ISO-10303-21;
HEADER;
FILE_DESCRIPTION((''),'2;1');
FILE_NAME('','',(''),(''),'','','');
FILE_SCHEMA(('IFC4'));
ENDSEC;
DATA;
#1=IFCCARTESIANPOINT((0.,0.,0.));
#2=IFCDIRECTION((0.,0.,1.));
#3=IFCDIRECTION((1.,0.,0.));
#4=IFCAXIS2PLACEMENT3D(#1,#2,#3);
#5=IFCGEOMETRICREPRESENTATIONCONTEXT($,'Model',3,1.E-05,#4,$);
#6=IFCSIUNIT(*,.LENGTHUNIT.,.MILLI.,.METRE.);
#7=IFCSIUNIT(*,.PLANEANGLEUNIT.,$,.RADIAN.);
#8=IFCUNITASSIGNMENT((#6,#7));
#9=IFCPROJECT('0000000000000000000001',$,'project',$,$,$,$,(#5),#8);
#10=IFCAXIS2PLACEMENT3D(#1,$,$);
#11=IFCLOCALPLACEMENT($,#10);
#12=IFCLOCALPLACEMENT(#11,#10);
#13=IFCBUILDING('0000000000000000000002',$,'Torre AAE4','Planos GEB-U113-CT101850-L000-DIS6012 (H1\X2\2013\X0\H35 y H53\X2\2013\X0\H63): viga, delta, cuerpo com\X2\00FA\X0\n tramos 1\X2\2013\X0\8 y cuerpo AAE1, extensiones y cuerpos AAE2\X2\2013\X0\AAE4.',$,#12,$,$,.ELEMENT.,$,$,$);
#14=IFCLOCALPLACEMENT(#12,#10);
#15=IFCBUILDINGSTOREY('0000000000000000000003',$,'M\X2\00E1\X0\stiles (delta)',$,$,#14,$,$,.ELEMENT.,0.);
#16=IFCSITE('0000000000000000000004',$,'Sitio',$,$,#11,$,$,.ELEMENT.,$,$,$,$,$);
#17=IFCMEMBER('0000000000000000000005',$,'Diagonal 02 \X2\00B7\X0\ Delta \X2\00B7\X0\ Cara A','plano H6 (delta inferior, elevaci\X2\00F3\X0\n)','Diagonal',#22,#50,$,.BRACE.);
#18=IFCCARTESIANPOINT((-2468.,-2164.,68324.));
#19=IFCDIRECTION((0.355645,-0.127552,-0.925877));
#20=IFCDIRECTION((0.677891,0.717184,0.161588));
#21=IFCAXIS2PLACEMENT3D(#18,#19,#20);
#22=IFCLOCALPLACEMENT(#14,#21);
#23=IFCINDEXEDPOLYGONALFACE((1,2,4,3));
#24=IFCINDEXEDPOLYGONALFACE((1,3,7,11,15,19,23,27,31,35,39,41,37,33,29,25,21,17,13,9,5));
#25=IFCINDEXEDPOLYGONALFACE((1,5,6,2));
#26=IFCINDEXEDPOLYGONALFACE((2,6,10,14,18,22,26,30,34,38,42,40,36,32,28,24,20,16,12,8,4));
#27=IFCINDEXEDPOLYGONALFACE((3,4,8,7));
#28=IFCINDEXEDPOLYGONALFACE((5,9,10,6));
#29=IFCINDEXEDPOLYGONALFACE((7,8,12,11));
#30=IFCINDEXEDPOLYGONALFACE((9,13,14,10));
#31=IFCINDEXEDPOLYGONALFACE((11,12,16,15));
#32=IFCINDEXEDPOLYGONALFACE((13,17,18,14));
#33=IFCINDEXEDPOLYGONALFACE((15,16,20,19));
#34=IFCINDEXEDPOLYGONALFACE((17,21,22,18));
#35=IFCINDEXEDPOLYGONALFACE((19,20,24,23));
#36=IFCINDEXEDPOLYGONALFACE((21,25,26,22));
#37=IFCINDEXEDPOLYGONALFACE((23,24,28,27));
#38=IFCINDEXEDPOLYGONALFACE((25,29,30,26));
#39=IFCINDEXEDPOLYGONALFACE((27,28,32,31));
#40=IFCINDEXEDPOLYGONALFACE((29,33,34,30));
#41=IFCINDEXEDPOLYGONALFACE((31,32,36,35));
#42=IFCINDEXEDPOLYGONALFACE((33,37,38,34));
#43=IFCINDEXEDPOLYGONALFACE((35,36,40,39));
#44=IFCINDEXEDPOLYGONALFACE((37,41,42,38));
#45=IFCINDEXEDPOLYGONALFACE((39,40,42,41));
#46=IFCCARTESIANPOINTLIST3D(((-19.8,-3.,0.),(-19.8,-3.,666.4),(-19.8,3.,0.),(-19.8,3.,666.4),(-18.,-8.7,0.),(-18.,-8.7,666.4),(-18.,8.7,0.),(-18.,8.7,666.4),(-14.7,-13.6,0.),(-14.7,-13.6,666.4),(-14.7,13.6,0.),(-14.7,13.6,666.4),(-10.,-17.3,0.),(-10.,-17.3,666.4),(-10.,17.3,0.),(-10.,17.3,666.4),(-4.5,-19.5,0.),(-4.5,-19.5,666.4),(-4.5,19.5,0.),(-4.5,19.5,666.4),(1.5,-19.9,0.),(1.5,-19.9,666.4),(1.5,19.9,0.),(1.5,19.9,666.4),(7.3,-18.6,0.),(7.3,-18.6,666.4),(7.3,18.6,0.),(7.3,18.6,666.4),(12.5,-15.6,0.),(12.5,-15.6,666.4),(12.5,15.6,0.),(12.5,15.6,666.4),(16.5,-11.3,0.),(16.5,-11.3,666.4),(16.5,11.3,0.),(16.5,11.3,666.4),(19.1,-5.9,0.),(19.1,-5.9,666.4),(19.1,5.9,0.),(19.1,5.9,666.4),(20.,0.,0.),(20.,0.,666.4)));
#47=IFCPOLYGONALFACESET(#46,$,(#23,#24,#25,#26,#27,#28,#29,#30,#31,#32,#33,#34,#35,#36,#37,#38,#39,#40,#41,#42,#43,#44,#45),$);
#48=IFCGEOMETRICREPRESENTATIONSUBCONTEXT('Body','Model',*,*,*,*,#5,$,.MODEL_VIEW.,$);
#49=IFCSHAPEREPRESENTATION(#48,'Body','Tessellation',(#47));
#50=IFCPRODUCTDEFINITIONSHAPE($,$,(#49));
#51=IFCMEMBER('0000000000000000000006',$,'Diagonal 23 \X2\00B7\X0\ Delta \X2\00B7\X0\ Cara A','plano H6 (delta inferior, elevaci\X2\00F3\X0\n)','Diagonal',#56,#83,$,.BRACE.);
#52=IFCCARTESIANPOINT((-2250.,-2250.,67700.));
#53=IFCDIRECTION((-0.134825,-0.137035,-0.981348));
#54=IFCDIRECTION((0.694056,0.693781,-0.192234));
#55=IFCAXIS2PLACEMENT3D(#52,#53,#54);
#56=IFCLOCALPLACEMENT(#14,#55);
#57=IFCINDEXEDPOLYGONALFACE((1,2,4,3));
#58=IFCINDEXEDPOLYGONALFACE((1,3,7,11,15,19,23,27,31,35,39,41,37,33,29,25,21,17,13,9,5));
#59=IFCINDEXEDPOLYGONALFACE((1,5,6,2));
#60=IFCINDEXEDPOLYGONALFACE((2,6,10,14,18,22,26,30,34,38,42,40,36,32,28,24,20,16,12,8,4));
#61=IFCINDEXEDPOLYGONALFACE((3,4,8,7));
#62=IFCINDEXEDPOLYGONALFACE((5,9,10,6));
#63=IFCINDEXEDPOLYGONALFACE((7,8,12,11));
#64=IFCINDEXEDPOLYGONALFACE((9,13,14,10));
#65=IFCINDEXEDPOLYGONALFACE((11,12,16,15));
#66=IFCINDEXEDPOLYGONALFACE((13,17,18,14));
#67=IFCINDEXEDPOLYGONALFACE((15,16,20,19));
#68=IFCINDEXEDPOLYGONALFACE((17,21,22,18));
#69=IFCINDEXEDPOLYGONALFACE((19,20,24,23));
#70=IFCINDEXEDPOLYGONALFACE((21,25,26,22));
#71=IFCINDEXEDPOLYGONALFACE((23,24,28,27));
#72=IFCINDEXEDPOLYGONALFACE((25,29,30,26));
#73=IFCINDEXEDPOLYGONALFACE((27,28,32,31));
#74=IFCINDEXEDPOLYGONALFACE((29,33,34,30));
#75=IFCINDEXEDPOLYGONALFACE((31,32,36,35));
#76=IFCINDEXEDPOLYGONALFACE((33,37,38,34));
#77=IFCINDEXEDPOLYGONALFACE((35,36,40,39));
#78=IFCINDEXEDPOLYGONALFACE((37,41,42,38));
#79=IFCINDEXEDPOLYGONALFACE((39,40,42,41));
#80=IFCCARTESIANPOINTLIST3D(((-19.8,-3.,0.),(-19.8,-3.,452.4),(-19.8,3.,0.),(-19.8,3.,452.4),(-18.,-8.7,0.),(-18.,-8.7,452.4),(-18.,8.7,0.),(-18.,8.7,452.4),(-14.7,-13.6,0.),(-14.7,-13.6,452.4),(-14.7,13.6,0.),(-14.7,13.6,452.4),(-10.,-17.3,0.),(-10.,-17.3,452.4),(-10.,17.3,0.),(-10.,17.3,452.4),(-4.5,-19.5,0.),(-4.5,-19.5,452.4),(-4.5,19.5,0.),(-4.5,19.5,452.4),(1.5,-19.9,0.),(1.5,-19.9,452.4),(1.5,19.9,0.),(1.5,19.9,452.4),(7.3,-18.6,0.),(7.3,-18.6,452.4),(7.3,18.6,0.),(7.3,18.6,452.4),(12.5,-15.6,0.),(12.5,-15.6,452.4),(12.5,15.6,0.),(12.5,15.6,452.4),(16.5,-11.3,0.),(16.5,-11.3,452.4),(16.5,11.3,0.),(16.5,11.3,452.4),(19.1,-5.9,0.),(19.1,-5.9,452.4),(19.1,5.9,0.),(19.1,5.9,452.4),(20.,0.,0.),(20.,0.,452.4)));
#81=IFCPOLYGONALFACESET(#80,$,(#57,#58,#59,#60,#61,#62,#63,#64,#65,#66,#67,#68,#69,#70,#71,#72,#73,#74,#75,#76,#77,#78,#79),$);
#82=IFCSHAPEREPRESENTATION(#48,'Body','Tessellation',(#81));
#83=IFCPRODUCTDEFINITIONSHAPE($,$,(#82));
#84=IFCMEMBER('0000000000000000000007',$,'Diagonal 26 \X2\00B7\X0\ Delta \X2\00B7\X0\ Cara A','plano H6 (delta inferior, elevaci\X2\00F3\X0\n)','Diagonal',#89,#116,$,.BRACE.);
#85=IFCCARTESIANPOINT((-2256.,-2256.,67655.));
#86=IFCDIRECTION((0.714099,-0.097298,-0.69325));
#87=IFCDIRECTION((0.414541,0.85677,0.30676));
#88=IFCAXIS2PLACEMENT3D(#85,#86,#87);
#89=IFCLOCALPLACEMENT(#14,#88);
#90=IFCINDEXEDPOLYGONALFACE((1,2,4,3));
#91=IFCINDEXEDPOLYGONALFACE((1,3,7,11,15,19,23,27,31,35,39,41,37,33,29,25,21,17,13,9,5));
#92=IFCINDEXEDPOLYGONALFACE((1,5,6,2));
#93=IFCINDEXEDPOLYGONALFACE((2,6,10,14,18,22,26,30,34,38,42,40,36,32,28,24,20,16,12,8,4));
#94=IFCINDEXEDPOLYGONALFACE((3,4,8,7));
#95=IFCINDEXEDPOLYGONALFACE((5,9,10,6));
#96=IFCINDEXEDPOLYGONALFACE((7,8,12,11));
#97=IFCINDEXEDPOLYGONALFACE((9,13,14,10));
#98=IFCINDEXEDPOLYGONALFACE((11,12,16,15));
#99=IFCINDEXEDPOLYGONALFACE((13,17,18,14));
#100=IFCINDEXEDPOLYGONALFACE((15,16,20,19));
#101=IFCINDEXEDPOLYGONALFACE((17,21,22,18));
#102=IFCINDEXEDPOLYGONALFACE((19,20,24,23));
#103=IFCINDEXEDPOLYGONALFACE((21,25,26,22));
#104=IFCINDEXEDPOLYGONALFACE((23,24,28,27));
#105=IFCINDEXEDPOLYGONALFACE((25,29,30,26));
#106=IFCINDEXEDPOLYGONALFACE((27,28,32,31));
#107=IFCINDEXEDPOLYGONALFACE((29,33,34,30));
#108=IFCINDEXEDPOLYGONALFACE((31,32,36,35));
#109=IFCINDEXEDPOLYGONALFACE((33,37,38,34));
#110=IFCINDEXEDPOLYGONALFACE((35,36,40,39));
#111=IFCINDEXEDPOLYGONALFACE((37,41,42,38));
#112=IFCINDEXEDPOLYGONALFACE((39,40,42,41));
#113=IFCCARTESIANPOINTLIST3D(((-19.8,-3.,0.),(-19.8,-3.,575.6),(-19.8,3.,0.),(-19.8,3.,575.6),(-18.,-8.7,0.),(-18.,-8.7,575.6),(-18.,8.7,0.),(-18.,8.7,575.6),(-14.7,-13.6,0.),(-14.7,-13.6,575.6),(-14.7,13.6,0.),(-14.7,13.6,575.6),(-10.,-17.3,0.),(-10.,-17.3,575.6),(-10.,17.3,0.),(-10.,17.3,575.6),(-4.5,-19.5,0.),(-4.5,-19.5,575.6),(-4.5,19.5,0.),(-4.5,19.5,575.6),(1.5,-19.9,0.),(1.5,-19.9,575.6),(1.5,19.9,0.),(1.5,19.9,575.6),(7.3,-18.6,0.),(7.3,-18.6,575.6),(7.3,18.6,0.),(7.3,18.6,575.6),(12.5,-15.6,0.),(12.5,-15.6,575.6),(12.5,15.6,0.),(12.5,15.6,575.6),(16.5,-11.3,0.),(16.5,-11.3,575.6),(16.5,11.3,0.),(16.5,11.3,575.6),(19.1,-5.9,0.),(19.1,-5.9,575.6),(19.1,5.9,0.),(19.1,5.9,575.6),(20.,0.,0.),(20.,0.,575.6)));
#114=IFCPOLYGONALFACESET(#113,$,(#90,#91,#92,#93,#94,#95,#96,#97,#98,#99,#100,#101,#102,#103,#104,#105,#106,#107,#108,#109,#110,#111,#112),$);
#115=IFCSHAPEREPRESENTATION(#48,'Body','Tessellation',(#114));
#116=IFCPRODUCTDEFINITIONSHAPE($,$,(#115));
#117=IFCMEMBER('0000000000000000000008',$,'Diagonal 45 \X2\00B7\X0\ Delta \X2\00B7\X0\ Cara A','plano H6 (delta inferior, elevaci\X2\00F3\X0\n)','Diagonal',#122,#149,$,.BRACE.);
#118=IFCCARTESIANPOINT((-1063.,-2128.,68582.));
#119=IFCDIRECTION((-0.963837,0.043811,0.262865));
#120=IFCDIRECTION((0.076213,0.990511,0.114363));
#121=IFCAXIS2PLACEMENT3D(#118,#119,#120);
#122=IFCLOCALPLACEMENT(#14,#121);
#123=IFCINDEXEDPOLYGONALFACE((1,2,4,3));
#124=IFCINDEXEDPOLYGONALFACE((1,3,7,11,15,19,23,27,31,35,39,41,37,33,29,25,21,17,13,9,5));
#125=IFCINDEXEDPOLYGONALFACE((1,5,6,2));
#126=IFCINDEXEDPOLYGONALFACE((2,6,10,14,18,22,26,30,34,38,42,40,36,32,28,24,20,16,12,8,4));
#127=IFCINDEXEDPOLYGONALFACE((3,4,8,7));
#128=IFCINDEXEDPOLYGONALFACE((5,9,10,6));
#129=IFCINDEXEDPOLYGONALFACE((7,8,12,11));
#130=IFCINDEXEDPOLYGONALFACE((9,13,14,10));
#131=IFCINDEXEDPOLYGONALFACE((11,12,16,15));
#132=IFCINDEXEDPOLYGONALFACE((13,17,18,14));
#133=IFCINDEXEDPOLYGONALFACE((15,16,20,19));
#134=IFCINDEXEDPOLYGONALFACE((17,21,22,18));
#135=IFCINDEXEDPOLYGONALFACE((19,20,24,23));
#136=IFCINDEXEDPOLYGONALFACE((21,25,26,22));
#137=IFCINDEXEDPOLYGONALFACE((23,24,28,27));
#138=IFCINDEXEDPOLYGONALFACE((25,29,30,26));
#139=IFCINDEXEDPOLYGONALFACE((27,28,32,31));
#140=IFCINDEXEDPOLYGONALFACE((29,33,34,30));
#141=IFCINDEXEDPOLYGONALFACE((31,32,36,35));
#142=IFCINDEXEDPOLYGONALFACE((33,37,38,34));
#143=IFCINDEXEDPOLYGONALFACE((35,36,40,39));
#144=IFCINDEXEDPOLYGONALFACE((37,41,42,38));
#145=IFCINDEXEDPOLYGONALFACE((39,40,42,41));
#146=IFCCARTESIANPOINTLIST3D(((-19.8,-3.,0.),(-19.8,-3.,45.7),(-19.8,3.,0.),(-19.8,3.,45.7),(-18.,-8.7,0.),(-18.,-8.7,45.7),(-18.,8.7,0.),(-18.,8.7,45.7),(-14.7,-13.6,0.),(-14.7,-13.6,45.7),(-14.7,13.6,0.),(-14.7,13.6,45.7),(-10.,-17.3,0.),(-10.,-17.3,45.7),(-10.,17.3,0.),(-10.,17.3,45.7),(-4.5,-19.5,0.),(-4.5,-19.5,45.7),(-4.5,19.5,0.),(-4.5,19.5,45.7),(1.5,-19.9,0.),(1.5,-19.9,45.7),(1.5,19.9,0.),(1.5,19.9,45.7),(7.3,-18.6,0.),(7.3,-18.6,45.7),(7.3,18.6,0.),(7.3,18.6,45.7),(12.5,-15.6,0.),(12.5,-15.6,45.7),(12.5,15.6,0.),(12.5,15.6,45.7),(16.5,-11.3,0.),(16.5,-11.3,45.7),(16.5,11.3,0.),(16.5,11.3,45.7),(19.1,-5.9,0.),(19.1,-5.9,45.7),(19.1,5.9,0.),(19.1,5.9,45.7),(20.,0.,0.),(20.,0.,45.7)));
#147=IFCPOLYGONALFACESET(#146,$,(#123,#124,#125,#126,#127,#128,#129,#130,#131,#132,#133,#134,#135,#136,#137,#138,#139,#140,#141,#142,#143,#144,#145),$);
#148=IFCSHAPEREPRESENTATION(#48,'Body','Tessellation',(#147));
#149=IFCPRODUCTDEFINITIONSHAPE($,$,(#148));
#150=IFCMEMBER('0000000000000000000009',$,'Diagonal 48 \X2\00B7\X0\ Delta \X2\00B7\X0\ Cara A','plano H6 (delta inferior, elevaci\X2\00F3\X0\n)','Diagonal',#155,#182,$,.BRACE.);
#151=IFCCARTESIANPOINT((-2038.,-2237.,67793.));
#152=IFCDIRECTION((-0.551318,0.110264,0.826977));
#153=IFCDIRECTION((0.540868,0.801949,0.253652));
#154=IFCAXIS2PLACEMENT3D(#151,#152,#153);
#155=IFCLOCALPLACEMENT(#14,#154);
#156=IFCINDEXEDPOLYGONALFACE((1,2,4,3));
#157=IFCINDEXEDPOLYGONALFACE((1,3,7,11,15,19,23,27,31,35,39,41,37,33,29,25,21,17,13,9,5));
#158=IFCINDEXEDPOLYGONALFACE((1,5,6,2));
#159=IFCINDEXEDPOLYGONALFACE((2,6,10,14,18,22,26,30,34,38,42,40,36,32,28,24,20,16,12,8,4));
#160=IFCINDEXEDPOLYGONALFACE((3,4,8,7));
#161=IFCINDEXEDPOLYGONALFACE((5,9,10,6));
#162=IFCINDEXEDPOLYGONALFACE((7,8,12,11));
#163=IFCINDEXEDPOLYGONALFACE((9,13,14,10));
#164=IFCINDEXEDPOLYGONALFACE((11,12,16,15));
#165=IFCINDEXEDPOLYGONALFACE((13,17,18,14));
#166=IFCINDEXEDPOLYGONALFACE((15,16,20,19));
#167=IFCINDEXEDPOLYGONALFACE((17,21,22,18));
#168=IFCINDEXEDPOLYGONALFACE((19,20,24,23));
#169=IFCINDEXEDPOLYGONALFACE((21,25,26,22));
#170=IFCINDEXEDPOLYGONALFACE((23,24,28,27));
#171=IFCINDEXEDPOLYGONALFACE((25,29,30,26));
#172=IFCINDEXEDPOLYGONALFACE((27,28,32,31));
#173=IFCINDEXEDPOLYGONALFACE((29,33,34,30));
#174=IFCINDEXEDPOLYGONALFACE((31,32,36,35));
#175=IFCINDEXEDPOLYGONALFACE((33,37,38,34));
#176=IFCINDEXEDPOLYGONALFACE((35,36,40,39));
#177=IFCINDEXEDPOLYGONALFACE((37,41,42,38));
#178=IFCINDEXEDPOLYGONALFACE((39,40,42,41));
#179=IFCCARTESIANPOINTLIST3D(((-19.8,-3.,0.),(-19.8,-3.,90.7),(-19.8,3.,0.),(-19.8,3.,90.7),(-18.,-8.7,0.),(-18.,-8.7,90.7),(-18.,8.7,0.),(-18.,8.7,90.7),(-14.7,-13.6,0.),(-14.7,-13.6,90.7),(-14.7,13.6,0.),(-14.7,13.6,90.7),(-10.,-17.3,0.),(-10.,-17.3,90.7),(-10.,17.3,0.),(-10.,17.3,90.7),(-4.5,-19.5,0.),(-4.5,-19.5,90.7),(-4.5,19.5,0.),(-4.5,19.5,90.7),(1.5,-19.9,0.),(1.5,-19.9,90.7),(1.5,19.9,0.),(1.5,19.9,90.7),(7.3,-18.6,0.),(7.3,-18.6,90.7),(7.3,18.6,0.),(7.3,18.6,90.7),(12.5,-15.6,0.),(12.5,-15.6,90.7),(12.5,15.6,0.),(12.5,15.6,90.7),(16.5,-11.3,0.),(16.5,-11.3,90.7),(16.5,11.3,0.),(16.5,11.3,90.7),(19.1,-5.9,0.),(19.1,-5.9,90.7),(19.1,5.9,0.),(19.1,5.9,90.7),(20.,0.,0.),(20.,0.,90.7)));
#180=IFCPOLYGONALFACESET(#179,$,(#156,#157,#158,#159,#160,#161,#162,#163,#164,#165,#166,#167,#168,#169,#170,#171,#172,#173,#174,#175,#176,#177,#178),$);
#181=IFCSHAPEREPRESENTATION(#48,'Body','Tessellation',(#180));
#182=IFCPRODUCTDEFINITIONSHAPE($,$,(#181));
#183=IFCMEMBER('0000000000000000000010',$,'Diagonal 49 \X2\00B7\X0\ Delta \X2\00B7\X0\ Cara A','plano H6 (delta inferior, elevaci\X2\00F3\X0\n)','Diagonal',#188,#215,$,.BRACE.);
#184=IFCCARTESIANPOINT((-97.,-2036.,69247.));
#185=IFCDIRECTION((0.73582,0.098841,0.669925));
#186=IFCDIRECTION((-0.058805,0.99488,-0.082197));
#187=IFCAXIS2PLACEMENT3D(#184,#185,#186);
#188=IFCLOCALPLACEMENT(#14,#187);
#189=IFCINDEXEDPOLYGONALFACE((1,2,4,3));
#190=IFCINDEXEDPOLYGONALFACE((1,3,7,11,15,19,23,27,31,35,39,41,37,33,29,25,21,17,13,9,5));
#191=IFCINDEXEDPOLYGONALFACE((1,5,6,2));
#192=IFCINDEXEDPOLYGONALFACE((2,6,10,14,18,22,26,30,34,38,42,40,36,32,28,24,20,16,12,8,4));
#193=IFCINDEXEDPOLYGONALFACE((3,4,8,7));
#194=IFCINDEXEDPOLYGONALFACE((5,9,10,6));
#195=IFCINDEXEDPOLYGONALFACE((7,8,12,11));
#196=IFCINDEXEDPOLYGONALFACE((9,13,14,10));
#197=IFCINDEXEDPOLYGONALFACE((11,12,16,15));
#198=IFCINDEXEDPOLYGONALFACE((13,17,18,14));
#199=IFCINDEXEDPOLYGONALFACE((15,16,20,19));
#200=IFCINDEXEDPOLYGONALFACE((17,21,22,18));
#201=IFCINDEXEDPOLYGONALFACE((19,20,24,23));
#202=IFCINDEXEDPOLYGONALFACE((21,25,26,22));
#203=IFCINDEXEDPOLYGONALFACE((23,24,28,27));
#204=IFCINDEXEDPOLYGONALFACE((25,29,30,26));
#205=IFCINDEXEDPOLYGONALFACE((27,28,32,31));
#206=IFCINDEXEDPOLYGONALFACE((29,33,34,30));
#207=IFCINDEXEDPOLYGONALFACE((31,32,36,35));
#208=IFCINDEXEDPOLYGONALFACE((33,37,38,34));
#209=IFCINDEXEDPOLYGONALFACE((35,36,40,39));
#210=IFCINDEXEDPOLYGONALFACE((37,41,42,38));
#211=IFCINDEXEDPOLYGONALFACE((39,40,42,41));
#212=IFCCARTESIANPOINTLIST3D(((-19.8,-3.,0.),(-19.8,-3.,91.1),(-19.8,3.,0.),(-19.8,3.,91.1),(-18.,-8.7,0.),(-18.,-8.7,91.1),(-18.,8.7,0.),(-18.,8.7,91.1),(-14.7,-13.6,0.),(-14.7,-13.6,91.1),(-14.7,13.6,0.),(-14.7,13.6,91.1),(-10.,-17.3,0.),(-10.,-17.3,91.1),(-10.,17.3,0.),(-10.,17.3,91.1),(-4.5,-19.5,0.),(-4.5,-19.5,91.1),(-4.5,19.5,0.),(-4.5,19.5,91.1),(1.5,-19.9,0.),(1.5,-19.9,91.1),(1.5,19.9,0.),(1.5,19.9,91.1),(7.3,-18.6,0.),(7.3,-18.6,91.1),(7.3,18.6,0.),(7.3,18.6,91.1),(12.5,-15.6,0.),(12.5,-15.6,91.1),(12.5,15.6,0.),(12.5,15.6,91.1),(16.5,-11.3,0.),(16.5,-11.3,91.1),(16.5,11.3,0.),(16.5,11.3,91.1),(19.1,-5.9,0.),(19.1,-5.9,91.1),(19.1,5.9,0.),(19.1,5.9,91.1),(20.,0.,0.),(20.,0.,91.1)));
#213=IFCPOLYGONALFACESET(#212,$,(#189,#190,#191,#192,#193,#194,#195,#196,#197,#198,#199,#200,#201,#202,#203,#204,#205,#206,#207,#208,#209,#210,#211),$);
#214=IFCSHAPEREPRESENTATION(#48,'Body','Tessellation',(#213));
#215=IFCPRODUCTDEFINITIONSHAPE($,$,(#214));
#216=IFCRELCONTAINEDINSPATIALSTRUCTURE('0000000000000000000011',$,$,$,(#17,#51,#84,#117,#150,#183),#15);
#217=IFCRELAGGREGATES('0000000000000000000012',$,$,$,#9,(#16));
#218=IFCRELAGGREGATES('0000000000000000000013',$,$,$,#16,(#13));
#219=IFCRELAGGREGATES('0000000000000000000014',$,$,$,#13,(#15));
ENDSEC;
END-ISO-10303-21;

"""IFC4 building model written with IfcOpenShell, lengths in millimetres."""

from ifc_helpers import new_model, si_unit, frame, origin, origin_with_axes, place, context, subcontext, project, spatial, circle, extrude, element, save


model = new_model("IFC4")

# Units and contexts
model_context = context("Model", 3, precision=1e-05, world=origin_with_axes())
body_context = subcontext(model_context, "Body", "Model", "MODEL_VIEW")
ifc_project = project(units=[si_unit("LENGTHUNIT", "METRE", prefix="MILLI"), si_unit("PLANEANGLEUNIT", "RADIAN")], contexts=[model_context])

# Site, building, storey
site_placement = place(None, origin())
site = spatial("IfcSite", under=ifc_project, at=site_placement, Name="Sitio", CompositionType="ELEMENT")
building_placement = place(site_placement, origin())
building = spatial("IfcBuilding", under=site, at=building_placement, Name="Torre AAE4", Description="Planos GEB-U113-CT101850-L000-DIS6012 (H1–H35 y H53–H63): viga, delta, cuerpo común tramos 1–8 y cuerpo AAE1, extensiones y cuerpos AAE2–AAE4.", CompositionType="ELEMENT")
storey_placement = place(building_placement, origin())
storey = spatial("IfcBuildingStorey", under=building, at=storey_placement, Name="Mástiles (delta)", CompositionType="ELEMENT", Elevation=0.0)

# Members
member_1_placement = place(storey_placement, frame((-2468.0, -2164.0, 68324.0), z_axis=(0.355645, -0.127552, -0.925877), x_axis=(0.677891, 0.717184, 0.161588)))
element("IfcMember", 1, at=member_1_placement, inside=storey, Name="Diagonal 02 · Delta · Cara A", Description="plano H6 (delta inferior, elevación)", ObjectType="Diagonal", PredefinedType="BRACE", context=body_context, shape_type="SweptSolid", body=[
    extrude(circle(Radius=20.0), None, (0.0, 0.0, 1.0), 666.4),
])
member_2_placement = place(storey_placement, frame((-2250.0, -2250.0, 67700.0), z_axis=(-0.134825, -0.137035, -0.981348), x_axis=(0.694056, 0.693781, -0.192234)))
element("IfcMember", 2, at=member_2_placement, inside=storey, Name="Diagonal 23 · Delta · Cara A", Description="plano H6 (delta inferior, elevación)", ObjectType="Diagonal", PredefinedType="BRACE", context=body_context, shape_type="SweptSolid", body=[
    extrude(circle(Radius=20.0), None, (0.0, 0.0, 1.0), 452.4),
])
member_3_placement = place(storey_placement, frame((-2256.0, -2256.0, 67655.0), z_axis=(0.714099, -0.097298, -0.69325), x_axis=(0.414541, 0.85677, 0.30676)))
element("IfcMember", 3, at=member_3_placement, inside=storey, Name="Diagonal 26 · Delta · Cara A", Description="plano H6 (delta inferior, elevación)", ObjectType="Diagonal", PredefinedType="BRACE", context=body_context, shape_type="SweptSolid", body=[
    extrude(circle(Radius=20.0), None, (0.0, 0.0, 1.0), 575.6),
])
member_4_placement = place(storey_placement, frame((-1063.0, -2128.0, 68582.0), z_axis=(-0.963837, 0.043811, 0.262865), x_axis=(0.076213, 0.990511, 0.114363)))
element("IfcMember", 4, at=member_4_placement, inside=storey, Name="Diagonal 45 · Delta · Cara A", Description="plano H6 (delta inferior, elevación)", ObjectType="Diagonal", PredefinedType="BRACE", context=body_context, shape_type="SweptSolid", body=[
    extrude(circle(Radius=20.0), None, (0.0, 0.0, 1.0), 45.7),
])
member_5_placement = place(storey_placement, frame((-2038.0, -2237.0, 67793.0), z_axis=(-0.551318, 0.110264, 0.826977), x_axis=(0.540868, 0.801949, 0.253652)))
element("IfcMember", 5, at=member_5_placement, inside=storey, Name="Diagonal 48 · Delta · Cara A", Description="plano H6 (delta inferior, elevación)", ObjectType="Diagonal", PredefinedType="BRACE", context=body_context, shape_type="SweptSolid", body=[
    extrude(circle(Radius=20.0), None, (0.0, 0.0, 1.0), 90.7),
])
member_6_placement = place(storey_placement, frame((-97.0, -2036.0, 69247.0), z_axis=(0.73582, 0.098841, 0.669925), x_axis=(-0.058805, 0.99488, -0.082197)))
element("IfcMember", 6, at=member_6_placement, inside=storey, Name="Diagonal 49 · Delta · Cara A", Description="plano H6 (delta inferior, elevación)", ObjectType="Diagonal", PredefinedType="BRACE", context=body_context, shape_type="SweptSolid", body=[
    extrude(circle(Radius=20.0), None, (0.0, 0.0, 1.0), 91.1),
])

save(model, "model.ifc")
